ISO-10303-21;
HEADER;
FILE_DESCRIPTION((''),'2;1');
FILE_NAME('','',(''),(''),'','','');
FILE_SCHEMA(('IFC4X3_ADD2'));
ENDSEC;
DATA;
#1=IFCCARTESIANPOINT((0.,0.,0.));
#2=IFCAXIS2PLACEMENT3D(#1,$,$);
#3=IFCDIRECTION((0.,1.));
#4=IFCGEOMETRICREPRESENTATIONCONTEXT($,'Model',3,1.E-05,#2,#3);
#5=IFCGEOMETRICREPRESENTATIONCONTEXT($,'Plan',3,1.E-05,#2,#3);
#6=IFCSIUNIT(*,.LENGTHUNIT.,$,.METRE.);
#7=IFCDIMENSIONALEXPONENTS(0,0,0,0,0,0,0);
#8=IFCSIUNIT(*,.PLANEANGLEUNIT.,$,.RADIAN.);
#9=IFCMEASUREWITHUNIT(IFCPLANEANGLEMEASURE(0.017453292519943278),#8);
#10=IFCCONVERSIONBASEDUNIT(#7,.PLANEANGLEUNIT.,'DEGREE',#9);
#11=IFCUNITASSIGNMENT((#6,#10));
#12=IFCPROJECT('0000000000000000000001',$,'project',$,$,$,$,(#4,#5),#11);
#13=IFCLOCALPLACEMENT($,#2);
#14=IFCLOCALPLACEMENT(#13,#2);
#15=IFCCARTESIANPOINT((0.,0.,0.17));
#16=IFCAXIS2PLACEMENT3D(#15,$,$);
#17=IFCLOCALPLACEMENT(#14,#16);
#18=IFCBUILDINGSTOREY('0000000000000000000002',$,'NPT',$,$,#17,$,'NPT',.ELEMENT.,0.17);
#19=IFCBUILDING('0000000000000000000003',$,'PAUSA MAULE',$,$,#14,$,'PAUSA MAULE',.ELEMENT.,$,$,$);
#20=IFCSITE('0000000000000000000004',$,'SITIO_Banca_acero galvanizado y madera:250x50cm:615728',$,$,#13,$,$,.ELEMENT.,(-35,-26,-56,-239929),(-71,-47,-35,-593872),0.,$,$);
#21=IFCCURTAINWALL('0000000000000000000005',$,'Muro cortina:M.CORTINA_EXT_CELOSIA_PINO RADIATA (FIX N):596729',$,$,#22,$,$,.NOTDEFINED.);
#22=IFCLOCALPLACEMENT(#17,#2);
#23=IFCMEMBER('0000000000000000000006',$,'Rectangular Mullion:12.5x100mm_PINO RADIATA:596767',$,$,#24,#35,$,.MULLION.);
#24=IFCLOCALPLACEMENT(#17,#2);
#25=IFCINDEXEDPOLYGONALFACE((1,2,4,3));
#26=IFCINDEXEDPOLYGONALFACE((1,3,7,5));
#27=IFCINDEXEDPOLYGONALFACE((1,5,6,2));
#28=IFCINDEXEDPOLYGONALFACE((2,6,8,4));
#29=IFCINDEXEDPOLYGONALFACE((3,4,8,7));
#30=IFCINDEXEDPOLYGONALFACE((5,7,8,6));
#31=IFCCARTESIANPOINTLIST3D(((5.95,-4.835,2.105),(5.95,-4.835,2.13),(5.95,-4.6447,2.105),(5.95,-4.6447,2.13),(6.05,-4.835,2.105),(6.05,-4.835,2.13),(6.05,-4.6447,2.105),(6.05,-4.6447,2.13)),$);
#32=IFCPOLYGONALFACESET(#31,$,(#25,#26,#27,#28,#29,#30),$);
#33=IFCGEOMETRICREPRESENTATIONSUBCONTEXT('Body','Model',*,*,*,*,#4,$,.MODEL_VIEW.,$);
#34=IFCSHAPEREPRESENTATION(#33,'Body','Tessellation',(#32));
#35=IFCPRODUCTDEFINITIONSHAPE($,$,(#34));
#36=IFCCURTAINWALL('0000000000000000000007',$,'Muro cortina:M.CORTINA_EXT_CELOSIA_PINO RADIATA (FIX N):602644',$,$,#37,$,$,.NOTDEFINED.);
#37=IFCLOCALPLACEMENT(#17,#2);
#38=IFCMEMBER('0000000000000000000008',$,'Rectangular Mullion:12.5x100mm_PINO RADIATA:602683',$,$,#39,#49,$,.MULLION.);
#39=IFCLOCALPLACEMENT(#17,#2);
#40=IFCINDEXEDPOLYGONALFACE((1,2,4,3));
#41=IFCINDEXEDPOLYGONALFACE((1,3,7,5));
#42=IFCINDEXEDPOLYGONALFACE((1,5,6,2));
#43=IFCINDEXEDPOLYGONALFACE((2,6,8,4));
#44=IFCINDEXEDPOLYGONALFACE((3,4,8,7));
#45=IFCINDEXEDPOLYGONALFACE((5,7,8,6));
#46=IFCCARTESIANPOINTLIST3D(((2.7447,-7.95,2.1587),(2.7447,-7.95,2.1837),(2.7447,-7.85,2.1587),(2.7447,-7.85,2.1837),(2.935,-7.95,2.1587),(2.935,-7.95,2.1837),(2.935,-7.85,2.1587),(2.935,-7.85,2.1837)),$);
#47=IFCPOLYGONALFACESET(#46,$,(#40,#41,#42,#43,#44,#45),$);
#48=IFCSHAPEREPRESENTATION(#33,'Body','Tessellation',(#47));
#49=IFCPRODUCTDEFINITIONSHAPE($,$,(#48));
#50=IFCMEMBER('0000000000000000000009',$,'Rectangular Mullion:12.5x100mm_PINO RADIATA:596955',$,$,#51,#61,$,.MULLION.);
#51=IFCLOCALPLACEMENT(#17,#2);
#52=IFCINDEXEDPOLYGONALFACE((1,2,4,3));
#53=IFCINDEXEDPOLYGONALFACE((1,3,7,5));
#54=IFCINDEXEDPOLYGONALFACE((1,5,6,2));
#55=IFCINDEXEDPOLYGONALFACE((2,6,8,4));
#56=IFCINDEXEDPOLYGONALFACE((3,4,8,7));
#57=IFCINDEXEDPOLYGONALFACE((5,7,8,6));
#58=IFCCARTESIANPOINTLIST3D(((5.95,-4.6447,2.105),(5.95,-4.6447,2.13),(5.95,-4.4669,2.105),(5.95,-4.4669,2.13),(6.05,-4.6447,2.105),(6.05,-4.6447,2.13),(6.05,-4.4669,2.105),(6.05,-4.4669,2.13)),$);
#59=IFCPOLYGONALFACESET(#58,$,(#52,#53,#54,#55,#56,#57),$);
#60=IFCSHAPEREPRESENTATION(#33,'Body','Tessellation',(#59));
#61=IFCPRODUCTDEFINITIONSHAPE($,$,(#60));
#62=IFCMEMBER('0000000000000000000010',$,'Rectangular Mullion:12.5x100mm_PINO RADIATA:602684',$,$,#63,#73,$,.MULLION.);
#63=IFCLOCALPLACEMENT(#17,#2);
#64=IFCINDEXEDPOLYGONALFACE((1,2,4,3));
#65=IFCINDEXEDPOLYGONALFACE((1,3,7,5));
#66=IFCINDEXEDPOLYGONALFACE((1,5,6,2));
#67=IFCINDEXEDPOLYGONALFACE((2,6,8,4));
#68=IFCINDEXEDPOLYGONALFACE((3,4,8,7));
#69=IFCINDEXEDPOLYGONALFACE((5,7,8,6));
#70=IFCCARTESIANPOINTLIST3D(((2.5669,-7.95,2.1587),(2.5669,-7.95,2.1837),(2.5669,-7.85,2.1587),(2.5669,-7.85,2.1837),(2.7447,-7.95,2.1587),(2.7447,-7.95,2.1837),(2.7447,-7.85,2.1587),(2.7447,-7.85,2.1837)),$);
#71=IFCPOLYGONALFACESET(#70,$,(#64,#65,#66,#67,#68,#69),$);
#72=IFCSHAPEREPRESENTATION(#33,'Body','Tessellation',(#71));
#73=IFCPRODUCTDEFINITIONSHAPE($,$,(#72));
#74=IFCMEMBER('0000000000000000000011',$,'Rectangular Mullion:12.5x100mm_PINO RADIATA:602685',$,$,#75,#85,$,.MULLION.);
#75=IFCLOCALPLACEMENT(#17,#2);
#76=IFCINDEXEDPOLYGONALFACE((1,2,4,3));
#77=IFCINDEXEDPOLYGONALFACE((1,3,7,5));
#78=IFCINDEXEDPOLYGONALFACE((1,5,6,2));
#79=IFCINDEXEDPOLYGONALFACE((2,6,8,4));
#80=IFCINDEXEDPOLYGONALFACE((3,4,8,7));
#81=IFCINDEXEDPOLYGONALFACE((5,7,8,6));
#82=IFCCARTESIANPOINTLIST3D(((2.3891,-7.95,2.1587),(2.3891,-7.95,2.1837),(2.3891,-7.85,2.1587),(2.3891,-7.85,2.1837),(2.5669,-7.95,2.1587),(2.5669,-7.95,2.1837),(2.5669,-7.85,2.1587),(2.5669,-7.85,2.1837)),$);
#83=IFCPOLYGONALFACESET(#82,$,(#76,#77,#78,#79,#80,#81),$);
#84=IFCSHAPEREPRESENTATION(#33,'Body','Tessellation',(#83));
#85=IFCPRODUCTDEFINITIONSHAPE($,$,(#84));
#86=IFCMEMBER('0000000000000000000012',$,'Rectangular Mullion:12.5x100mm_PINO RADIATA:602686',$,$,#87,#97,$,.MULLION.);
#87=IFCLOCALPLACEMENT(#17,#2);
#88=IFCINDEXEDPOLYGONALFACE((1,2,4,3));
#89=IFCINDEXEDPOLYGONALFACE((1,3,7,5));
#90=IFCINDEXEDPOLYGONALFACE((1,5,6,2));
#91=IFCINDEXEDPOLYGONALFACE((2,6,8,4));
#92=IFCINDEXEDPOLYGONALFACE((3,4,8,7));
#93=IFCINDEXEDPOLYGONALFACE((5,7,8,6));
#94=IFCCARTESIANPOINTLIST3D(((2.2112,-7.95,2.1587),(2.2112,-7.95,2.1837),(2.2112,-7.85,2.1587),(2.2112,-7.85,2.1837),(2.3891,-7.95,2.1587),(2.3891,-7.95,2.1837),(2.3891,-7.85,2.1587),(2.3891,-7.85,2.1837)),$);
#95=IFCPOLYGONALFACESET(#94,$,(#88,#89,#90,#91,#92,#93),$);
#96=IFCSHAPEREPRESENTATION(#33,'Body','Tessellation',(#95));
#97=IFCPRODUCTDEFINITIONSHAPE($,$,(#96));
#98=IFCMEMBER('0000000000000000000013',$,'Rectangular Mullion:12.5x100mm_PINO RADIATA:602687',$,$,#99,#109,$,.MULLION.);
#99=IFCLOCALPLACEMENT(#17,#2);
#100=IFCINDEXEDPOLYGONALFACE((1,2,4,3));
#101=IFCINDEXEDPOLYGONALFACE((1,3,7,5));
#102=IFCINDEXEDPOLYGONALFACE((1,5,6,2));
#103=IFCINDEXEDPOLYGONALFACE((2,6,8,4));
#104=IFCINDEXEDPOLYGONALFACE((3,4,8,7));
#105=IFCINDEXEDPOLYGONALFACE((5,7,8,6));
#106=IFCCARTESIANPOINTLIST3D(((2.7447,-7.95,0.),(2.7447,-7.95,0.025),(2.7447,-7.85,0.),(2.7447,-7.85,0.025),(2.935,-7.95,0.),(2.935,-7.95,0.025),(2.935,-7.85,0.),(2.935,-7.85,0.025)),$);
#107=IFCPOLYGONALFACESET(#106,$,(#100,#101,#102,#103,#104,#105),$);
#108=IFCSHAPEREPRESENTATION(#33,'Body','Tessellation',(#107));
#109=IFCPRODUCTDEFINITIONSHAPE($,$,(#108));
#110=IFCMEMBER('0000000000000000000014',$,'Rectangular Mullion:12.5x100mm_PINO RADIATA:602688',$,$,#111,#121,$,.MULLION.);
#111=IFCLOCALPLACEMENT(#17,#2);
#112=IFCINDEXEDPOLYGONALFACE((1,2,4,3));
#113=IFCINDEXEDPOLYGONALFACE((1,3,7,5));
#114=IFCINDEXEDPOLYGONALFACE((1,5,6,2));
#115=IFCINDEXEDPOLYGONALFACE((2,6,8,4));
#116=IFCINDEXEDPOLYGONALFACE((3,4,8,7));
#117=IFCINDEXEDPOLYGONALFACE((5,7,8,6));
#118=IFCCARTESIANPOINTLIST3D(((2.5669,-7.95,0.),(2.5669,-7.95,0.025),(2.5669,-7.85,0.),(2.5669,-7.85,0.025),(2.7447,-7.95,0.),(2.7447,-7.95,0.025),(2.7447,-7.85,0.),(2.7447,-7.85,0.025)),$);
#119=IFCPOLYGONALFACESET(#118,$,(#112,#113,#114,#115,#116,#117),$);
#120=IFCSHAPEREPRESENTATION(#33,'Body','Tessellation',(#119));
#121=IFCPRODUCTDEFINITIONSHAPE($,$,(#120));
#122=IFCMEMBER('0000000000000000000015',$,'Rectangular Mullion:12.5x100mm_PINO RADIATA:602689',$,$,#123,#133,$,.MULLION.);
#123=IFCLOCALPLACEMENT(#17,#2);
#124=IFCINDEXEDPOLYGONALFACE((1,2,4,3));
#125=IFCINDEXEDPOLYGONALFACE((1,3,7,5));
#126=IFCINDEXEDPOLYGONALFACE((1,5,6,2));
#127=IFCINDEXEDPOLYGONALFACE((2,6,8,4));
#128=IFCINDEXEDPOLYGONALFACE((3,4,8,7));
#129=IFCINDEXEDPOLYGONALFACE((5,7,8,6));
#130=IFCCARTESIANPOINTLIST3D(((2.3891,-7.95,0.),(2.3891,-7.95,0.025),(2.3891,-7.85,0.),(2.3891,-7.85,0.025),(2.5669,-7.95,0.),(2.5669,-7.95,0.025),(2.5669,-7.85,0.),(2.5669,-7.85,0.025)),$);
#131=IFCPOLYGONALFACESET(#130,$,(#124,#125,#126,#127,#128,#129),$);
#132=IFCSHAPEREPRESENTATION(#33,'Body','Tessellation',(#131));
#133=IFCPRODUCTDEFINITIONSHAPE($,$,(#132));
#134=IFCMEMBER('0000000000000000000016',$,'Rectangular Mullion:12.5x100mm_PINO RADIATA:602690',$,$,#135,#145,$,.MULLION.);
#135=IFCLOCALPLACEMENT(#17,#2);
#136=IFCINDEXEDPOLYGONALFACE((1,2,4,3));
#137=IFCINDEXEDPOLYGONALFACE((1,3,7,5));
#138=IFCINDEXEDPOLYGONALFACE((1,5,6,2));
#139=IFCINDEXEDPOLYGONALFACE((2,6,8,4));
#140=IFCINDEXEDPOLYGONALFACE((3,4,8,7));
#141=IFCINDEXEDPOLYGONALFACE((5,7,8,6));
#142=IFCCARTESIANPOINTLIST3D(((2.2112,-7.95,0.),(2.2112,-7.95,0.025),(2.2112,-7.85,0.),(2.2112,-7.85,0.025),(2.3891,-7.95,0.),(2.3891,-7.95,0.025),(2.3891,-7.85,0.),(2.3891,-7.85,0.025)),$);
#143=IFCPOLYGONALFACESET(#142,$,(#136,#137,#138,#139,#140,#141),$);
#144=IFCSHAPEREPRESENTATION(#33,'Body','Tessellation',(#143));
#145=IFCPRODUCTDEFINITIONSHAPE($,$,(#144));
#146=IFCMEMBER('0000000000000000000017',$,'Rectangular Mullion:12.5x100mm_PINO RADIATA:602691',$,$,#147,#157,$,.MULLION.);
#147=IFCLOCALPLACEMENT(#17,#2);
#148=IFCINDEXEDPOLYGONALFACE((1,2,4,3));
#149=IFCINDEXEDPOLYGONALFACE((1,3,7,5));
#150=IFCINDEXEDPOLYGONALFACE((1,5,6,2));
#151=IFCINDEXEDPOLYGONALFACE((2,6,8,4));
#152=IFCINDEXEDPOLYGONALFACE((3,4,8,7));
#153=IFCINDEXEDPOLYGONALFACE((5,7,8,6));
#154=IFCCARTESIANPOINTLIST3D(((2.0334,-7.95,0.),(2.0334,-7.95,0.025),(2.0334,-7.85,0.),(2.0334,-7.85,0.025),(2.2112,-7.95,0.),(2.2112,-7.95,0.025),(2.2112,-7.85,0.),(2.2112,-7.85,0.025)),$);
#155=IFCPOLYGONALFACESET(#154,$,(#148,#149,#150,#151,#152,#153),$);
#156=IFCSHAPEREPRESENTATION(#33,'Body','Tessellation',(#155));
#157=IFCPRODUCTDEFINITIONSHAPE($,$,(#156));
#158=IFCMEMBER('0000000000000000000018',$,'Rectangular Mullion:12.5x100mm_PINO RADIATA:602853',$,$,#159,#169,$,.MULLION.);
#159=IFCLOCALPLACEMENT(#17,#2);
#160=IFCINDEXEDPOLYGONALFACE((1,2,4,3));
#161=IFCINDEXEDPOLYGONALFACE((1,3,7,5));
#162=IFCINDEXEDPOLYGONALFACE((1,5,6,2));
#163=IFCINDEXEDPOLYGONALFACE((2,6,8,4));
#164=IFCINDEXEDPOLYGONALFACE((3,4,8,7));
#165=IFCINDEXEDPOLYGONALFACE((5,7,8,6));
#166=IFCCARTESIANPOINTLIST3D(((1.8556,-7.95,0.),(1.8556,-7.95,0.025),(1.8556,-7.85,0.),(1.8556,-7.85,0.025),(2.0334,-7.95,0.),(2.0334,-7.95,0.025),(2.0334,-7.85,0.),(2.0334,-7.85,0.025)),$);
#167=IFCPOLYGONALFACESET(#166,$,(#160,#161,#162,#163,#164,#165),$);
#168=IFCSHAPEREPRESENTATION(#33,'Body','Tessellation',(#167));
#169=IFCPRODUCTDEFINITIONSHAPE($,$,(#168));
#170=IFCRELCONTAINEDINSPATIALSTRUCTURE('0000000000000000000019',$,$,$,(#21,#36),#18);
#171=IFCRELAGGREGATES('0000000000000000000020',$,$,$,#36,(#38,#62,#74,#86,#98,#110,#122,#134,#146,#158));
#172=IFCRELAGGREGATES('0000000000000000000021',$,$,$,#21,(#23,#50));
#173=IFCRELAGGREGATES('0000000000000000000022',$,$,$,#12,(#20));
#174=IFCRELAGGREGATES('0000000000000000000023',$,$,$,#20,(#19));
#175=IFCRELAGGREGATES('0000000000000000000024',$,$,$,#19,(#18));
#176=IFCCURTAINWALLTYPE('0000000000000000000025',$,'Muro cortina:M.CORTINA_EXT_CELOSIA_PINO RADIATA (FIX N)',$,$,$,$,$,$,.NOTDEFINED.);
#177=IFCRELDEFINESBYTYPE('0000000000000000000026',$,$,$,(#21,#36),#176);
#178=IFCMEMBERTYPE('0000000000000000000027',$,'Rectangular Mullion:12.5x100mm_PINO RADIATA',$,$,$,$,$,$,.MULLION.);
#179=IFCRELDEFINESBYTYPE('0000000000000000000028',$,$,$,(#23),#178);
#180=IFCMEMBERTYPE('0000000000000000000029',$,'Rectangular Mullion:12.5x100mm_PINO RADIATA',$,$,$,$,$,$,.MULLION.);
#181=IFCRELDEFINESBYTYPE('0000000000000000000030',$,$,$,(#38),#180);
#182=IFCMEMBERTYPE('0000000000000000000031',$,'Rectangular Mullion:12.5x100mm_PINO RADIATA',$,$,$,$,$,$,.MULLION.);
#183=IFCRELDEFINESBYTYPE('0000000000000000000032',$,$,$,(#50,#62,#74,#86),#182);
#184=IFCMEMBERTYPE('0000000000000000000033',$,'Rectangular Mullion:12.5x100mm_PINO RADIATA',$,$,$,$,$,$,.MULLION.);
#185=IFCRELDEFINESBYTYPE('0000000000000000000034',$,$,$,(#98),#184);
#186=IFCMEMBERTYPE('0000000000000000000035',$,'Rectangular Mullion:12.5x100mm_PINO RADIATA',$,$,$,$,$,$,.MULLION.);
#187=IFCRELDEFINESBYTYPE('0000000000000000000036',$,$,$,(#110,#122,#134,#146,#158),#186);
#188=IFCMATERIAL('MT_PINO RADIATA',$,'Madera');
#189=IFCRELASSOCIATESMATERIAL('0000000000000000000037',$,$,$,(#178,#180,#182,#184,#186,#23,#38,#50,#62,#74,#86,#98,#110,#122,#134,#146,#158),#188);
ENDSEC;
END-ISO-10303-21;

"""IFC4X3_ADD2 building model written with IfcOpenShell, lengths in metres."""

from ifc_helpers import new_model, entity, si_unit, converted_unit, direction, frame, frame_2d, origin, place, context, subcontext, project, spatial, rectangle, extrude, source, transform, mapped, material, material_profile, profile_set, profile_usage, type_object, type_shapes, element, aggregate, save


model = new_model("IFC4X3_ADD2")

# Units and contexts
model_context = context("Model", 3, precision=1e-05, world=origin(), true_north=direction((0.0, 1.0)))
plan_context = context("Plan", 3, precision=1e-05, world=origin(), true_north=direction((0.0, 1.0)))
body_context = subcontext(model_context, "Body", "Model", "MODEL_VIEW")
ifc_project = project(units=[si_unit("LENGTHUNIT", "METRE"), converted_unit("PLANEANGLEUNIT", "DEGREE", entity("IfcPlaneAngleMeasure", 0.017453292519943278), si_unit("PLANEANGLEUNIT", "RADIAN"), dimensions=[0, 0, 0, 0, 0, 0, 0])], contexts=[model_context, plan_context])

# Site, building, storey
site_placement = place(None, origin())
site = spatial("IfcSite", under=ifc_project, at=site_placement, Name="SITIO_Banca_acero galvanizado y madera:250x50cm:615728", CompositionType="ELEMENT", RefLatitude=(-35, -26, -56, -239929), RefLongitude=(-71, -47, -35, -593872), RefElevation=0.0)
building_placement = place(site_placement, origin())
building = spatial("IfcBuilding", under=site, at=building_placement, Name="PAUSA MAULE", LongName="PAUSA MAULE", CompositionType="ELEMENT")
storey_placement = place(building_placement, frame((0.0, 0.0, 0.17)))
storey = spatial("IfcBuildingStorey", under=building, at=storey_placement, Name="NPT", LongName="NPT", CompositionType="ELEMENT", Elevation=0.17)

# Curtain walls, members
curtain_wall_type = type_object("IfcCurtainWallType", Name="Muro cortina:M.CORTINA_EXT_CELOSIA_PINO RADIATA (FIX N)", PredefinedType="NOTDEFINED")
curtain_wall_1_placement = place(storey_placement, frame((0.0, 0.0, -0.17)))
curtain_wall_1 = element("IfcCurtainWall", 1, at=curtain_wall_1_placement, inside=storey, type_object=curtain_wall_type, Name="Muro cortina:M.CORTINA_EXT_CELOSIA_PINO RADIATA (FIX N):596729", PredefinedType="NOTDEFINED")
ifc_material = material(Name="MT_PINO RADIATA", Category="Madera")
ifc_material_profile = material_profile(ifc_material, rectangle(XDim=0.025, YDim=0.1, at=frame_2d((0.0, 0.0), x_axis=(1.0, 0.0))), Name="12.5x100mm_PINO RADIATA")
ifc_profile_set = profile_set([ifc_material_profile], Name="12.5x100mm_PINO RADIATA")
ifc_profile_usage = profile_usage(ifc_profile_set)
member_type_1 = type_object("IfcMemberType", Name="Rectangular Mullion:12.5x100mm_PINO RADIATA", PredefinedType="MULLION", material=ifc_profile_set)
shared_shape_1 = source(origin(), body_context, "Body", "SweptSolid", [
    extrude(rectangle(XDim=0.025, YDim=0.1, at=frame_2d((0.0, 0.0), x_axis=(1.0, 0.0))), frame((-0.0125, 0.0, -0.1903), z_axis=(0.0, 0.0, 1.0), x_axis=(-1.0, 0.0, 0.0)), (0.0, 0.0, 1.0), 0.1903),
])
type_shapes(member_type_1, [shared_shape_1])
member_1_placement = place(curtain_wall_1_placement, frame((6.0, -4.835, 2.3), z_axis=(0.0, -1.0, 0.0), x_axis=(0.0, 0.0, 1.0)))
member_1 = element("IfcMember", 2, at=member_1_placement, type_object=member_type_1, material=ifc_profile_usage, Name="Rectangular Mullion:12.5x100mm_PINO RADIATA:596767", PredefinedType="MULLION", context=body_context, shape_type="MappedRepresentation", body=[
    mapped(shared_shape_1, transform((0.0, 0.0, 0.0), scale=1.0)),
])
curtain_wall_2_placement = place(storey_placement, frame((0.0, 0.0, -0.17)))
curtain_wall_2 = element("IfcCurtainWall", 3, at=curtain_wall_2_placement, inside=storey, type_object=curtain_wall_type, Name="Muro cortina:M.CORTINA_EXT_CELOSIA_PINO RADIATA (FIX N):602644", PredefinedType="NOTDEFINED")
member_type_2 = type_object("IfcMemberType", Name="Rectangular Mullion:12.5x100mm_PINO RADIATA", PredefinedType="MULLION", material=ifc_profile_set)
shared_shape_2 = source(origin(), body_context, "Body", "SweptSolid", [
    extrude(rectangle(XDim=0.025, YDim=0.1, at=frame_2d((0.0, 0.0), x_axis=(1.0, 0.0))), frame((-0.0125, 0.0, -0.1903), z_axis=(0.0, 0.0, 1.0), x_axis=(-1.0, 0.0, 0.0)), (0.0, 0.0, 1.0), 0.1903),
])
type_shapes(member_type_2, [shared_shape_2])
member_2_placement = place(curtain_wall_2_placement, frame((2.7447, -7.9, 2.3537), z_axis=(-1.0, 0.0, 0.0), x_axis=(0.0, 0.0, 1.0)))
member_2 = element("IfcMember", 4, at=member_2_placement, type_object=member_type_2, material=ifc_profile_usage, Name="Rectangular Mullion:12.5x100mm_PINO RADIATA:602683", PredefinedType="MULLION", context=body_context, shape_type="MappedRepresentation", body=[
    mapped(shared_shape_2, transform((0.0, 0.0, 0.0), scale=1.0)),
])

# Members
member_type_3 = type_object("IfcMemberType", Name="Rectangular Mullion:12.5x100mm_PINO RADIATA", PredefinedType="MULLION", material=ifc_profile_set)
shared_shape_3 = source(origin(), body_context, "Body", "SweptSolid", [
    extrude(rectangle(XDim=0.025, YDim=0.1, at=frame_2d((0.0, 0.0), x_axis=(1.0, 0.0))), frame((-0.0125, 0.0, -0.1778), z_axis=(0.0, 0.0, 1.0), x_axis=(-1.0, 0.0, 0.0)), (0.0, 0.0, 1.0), 0.1778),
])
type_shapes(member_type_3, [shared_shape_3])
member_3_placement = place(curtain_wall_1_placement, frame((6.0, -4.6447, 2.3), z_axis=(0.0, -1.0, 0.0), x_axis=(0.0, 0.0, 1.0)))
member_3 = element("IfcMember", 5, at=member_3_placement, type_object=member_type_3, material=ifc_profile_usage, Name="Rectangular Mullion:12.5x100mm_PINO RADIATA:596955", PredefinedType="MULLION", context=body_context, shape_type="MappedRepresentation", body=[
    mapped(shared_shape_3, transform((0.0, 0.0, 0.0), scale=1.0)),
])
member_4_placement = place(curtain_wall_2_placement, frame((2.5669, -7.9, 2.3537), z_axis=(-1.0, 0.0, 0.0), x_axis=(0.0, 0.0, 1.0)))
member_4 = element("IfcMember", 6, at=member_4_placement, type_object=member_type_3, material=ifc_profile_usage, Name="Rectangular Mullion:12.5x100mm_PINO RADIATA:602684", PredefinedType="MULLION", context=body_context, shape_type="MappedRepresentation", body=[
    mapped(shared_shape_3, transform((0.0, 0.0, 0.0), scale=1.0)),
])
member_5_placement = place(curtain_wall_2_placement, frame((2.3891, -7.9, 2.3537), z_axis=(-1.0, 0.0, 0.0), x_axis=(0.0, 0.0, 1.0)))
member_5 = element("IfcMember", 7, at=member_5_placement, type_object=member_type_3, material=ifc_profile_usage, Name="Rectangular Mullion:12.5x100mm_PINO RADIATA:602685", PredefinedType="MULLION", context=body_context, shape_type="MappedRepresentation", body=[
    mapped(shared_shape_3, transform((0.0, 0.0, 0.0), scale=1.0)),
])
member_6_placement = place(curtain_wall_2_placement, frame((2.2112, -7.9, 2.3537), z_axis=(-1.0, 0.0, 0.0), x_axis=(0.0, 0.0, 1.0)))
member_6 = element("IfcMember", 8, at=member_6_placement, type_object=member_type_3, material=ifc_profile_usage, Name="Rectangular Mullion:12.5x100mm_PINO RADIATA:602686", PredefinedType="MULLION", context=body_context, shape_type="MappedRepresentation", body=[
    mapped(shared_shape_3, transform((0.0, 0.0, 0.0), scale=1.0)),
])
member_type_4 = type_object("IfcMemberType", Name="Rectangular Mullion:12.5x100mm_PINO RADIATA", PredefinedType="MULLION", material=ifc_profile_set)
shared_shape_4 = source(origin(), body_context, "Body", "SweptSolid", [
    extrude(rectangle(XDim=0.025, YDim=0.1, at=frame_2d((0.0, 0.0), x_axis=(1.0, 0.0))), frame((-0.0125, 0.0, -0.1903), z_axis=(0.0, 0.0, 1.0), x_axis=(-1.0, 0.0, 0.0)), (0.0, 0.0, 1.0), 0.1903),
])
type_shapes(member_type_4, [shared_shape_4])
member_7_placement = place(curtain_wall_2_placement, frame((2.935, -7.9, 0.17), z_axis=(1.0, 0.0, 0.0), x_axis=(0.0, 0.0, -1.0)))
member_7 = element("IfcMember", 9, at=member_7_placement, type_object=member_type_4, material=ifc_profile_usage, Name="Rectangular Mullion:12.5x100mm_PINO RADIATA:602687", PredefinedType="MULLION", context=body_context, shape_type="MappedRepresentation", body=[
    mapped(shared_shape_4, transform((0.0, 0.0, 0.0), scale=1.0)),
])
member_type_5 = type_object("IfcMemberType", Name="Rectangular Mullion:12.5x100mm_PINO RADIATA", PredefinedType="MULLION", material=ifc_profile_set)
shared_shape_5 = source(origin(), body_context, "Body", "SweptSolid", [
    extrude(rectangle(XDim=0.025, YDim=0.1, at=frame_2d((0.0, 0.0), x_axis=(1.0, 0.0))), frame((-0.0125, 0.0, -0.1778), z_axis=(0.0, 0.0, 1.0), x_axis=(-1.0, 0.0, 0.0)), (0.0, 0.0, 1.0), 0.1778),
])
type_shapes(member_type_5, [shared_shape_5])
member_8_placement = place(curtain_wall_2_placement, frame((2.7447, -7.9, 0.17), z_axis=(1.0, 0.0, 0.0), x_axis=(0.0, 0.0, -1.0)))
member_8 = element("IfcMember", 10, at=member_8_placement, type_object=member_type_5, material=ifc_profile_usage, Name="Rectangular Mullion:12.5x100mm_PINO RADIATA:602688", PredefinedType="MULLION", context=body_context, shape_type="MappedRepresentation", body=[
    mapped(shared_shape_5, transform((0.0, 0.0, 0.0), scale=1.0)),
])
member_9_placement = place(curtain_wall_2_placement, frame((2.5669, -7.9, 0.17), z_axis=(1.0, 0.0, 0.0), x_axis=(0.0, 0.0, -1.0)))
member_9 = element("IfcMember", 11, at=member_9_placement, type_object=member_type_5, material=ifc_profile_usage, Name="Rectangular Mullion:12.5x100mm_PINO RADIATA:602689", PredefinedType="MULLION", context=body_context, shape_type="MappedRepresentation", body=[
    mapped(shared_shape_5, transform((0.0, 0.0, 0.0), scale=1.0)),
])
member_10_placement = place(curtain_wall_2_placement, frame((2.3891, -7.9, 0.17), z_axis=(1.0, 0.0, 0.0), x_axis=(0.0, 0.0, -1.0)))
member_10 = element("IfcMember", 12, at=member_10_placement, type_object=member_type_5, material=ifc_profile_usage, Name="Rectangular Mullion:12.5x100mm_PINO RADIATA:602690", PredefinedType="MULLION", context=body_context, shape_type="MappedRepresentation", body=[
    mapped(shared_shape_5, transform((0.0, 0.0, 0.0), scale=1.0)),
])
member_11_placement = place(curtain_wall_2_placement, frame((2.2112, -7.9, 0.17), z_axis=(1.0, 0.0, 0.0), x_axis=(0.0, 0.0, -1.0)))
member_11 = element("IfcMember", 13, at=member_11_placement, type_object=member_type_5, material=ifc_profile_usage, Name="Rectangular Mullion:12.5x100mm_PINO RADIATA:602691", PredefinedType="MULLION", context=body_context, shape_type="MappedRepresentation", body=[
    mapped(shared_shape_5, transform((0.0, 0.0, 0.0), scale=1.0)),
])
member_12_placement = place(curtain_wall_2_placement, frame((2.0334, -7.9, 0.17), z_axis=(1.0, 0.0, 0.0), x_axis=(0.0, 0.0, -1.0)))
member_12 = element("IfcMember", 14, at=member_12_placement, type_object=member_type_5, material=ifc_profile_usage, Name="Rectangular Mullion:12.5x100mm_PINO RADIATA:602853", PredefinedType="MULLION", context=body_context, shape_type="MappedRepresentation", body=[
    mapped(shared_shape_5, transform((0.0, 0.0, 0.0), scale=1.0)),
])
aggregate(curtain_wall_2, [member_2, member_4, member_5, member_6, member_7, member_8, member_9, member_10, member_11, member_12])
aggregate(curtain_wall_1, [member_1, member_3])

save(model, "model.ifc")
